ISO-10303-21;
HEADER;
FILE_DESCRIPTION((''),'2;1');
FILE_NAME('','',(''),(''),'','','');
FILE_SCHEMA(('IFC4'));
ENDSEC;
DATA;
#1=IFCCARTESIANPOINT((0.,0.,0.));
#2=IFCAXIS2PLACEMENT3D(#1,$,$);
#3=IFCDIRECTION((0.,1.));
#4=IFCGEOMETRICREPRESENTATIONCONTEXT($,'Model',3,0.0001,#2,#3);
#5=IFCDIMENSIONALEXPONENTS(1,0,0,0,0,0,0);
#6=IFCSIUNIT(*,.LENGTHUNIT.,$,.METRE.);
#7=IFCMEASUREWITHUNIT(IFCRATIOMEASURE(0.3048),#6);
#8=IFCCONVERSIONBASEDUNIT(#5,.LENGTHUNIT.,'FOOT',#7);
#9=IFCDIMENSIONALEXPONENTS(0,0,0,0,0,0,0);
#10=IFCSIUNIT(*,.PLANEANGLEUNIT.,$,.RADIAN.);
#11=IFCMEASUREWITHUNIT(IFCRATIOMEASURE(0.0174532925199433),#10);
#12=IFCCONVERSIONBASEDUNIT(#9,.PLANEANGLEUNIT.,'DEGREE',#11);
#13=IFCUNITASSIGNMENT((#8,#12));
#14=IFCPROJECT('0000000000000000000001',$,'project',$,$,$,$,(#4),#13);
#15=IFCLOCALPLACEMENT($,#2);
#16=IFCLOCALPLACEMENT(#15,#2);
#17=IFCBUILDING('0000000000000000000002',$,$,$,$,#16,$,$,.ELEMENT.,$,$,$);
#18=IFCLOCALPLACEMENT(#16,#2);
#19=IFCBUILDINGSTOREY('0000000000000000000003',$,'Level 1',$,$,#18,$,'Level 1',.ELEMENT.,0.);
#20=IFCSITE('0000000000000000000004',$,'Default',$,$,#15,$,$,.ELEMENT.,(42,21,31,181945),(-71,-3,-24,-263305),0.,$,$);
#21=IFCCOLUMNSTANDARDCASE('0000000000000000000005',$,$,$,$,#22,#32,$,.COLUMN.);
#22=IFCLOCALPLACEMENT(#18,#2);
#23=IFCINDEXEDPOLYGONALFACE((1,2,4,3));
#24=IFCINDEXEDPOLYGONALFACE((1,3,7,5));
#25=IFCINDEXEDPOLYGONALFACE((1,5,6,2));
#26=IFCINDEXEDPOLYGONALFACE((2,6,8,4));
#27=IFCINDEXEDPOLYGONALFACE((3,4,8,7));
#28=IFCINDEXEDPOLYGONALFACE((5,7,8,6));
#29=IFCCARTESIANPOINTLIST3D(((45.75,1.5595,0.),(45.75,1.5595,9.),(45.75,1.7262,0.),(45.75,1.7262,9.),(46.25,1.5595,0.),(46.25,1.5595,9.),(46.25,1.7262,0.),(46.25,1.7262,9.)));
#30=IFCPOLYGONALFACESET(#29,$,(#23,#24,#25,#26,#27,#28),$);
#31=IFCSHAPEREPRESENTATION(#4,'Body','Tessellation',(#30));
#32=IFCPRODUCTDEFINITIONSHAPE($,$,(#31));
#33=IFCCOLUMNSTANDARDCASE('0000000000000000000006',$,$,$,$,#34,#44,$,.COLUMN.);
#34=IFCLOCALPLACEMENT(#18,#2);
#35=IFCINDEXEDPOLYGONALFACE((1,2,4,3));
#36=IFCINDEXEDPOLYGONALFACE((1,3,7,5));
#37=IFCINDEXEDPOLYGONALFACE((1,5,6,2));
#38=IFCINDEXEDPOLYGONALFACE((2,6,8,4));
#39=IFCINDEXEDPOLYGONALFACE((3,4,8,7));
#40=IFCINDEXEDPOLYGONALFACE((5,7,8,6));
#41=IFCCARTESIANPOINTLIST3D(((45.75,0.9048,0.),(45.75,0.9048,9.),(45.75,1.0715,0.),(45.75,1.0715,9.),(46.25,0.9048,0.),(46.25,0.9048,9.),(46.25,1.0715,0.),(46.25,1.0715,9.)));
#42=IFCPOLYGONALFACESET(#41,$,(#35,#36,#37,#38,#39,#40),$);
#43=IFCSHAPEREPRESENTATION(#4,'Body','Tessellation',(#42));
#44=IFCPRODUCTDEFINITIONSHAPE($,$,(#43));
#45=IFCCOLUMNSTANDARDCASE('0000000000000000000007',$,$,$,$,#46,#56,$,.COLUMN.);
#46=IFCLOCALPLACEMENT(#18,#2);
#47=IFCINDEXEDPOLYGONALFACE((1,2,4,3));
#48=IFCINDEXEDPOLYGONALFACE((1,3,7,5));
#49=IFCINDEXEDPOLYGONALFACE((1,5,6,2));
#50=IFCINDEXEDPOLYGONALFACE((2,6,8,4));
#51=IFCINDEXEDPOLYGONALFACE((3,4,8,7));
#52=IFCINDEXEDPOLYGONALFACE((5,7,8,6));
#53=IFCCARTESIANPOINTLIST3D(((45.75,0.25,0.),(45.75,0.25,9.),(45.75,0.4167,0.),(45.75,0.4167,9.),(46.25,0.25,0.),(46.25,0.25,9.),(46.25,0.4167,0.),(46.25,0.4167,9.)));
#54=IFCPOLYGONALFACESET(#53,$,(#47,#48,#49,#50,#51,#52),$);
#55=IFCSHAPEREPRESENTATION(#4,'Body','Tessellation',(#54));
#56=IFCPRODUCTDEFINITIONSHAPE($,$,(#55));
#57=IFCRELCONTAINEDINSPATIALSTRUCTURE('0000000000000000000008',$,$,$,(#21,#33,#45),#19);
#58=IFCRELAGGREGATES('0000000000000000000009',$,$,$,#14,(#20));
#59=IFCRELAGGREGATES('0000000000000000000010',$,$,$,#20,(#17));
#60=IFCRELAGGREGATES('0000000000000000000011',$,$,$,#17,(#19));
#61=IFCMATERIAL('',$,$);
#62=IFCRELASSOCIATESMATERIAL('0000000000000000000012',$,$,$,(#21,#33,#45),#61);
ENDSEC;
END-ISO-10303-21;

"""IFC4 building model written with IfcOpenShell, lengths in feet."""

from ifc_helpers import new_model, entity, si_unit, converted_unit, direction, frame, origin, place, context, project, spatial, rectangle, extrude, material, element, save


model = new_model("IFC4")

# Units and contexts
model_context = context("Model", 3, precision=0.0001, world=origin(), true_north=direction((0.0, 1.0)))
ifc_project = project(units=[converted_unit("LENGTHUNIT", "FOOT", entity("IfcRatioMeasure", 0.3048), si_unit("LENGTHUNIT", "METRE"), dimensions=[1, 0, 0, 0, 0, 0, 0]), converted_unit("PLANEANGLEUNIT", "DEGREE", entity("IfcRatioMeasure", 0.0174532925199433), si_unit("PLANEANGLEUNIT", "RADIAN"), dimensions=[0, 0, 0, 0, 0, 0, 0])], contexts=[model_context])

# Site, building, storey
site_placement = place(None, origin())
site = spatial("IfcSite", under=ifc_project, at=site_placement, Name="Default", CompositionType="ELEMENT", RefLatitude=(42, 21, 31, 181945), RefLongitude=(-71, -3, -24, -263305), RefElevation=0.0)
building_placement = place(site_placement, origin())
building = spatial("IfcBuilding", under=site, at=building_placement, CompositionType="ELEMENT")
storey_placement = place(building_placement, origin())
storey = spatial("IfcBuildingStorey", under=building, at=storey_placement, Name="Level 1", LongName="Level 1", CompositionType="ELEMENT", Elevation=0.0)

# Columns
ifc_material_1 = material(Name="")
placement_1 = place(storey_placement, frame((46.0, 46.25, 0.0), z_axis=(0.0, 0.0, 1.0), x_axis=(0.0, -1.0, 0.0)))
for number, where, z_axis, x_axis in (
    (1, (44.6071, 0.0, 0.0), (0.0, 0.0, 1.0), (1.0, 0.0, 0.0)),
    (2, (45.2619, 0.0, 0.0), (0.0, 0.0, 1.0), (1.0, 0.0, 0.0)),
    (3, (45.9167, 0.0, 0.0), (0.0, 0.0, 1.0), (1.0, 0.0, 0.0)),
):
    element("IfcColumnStandardCase", number, at=place(placement_1, frame(where, z_axis=z_axis, x_axis=x_axis)), inside=storey, material=ifc_material_1, PredefinedType="COLUMN", context=model_context, shape_type="SweptSolid", body=[
        extrude(rectangle(XDim=0.1667, YDim=0.5), origin(), (0.0, 0.0, 1.0), 9.0),
    ])

save(model, "model.ifc")
